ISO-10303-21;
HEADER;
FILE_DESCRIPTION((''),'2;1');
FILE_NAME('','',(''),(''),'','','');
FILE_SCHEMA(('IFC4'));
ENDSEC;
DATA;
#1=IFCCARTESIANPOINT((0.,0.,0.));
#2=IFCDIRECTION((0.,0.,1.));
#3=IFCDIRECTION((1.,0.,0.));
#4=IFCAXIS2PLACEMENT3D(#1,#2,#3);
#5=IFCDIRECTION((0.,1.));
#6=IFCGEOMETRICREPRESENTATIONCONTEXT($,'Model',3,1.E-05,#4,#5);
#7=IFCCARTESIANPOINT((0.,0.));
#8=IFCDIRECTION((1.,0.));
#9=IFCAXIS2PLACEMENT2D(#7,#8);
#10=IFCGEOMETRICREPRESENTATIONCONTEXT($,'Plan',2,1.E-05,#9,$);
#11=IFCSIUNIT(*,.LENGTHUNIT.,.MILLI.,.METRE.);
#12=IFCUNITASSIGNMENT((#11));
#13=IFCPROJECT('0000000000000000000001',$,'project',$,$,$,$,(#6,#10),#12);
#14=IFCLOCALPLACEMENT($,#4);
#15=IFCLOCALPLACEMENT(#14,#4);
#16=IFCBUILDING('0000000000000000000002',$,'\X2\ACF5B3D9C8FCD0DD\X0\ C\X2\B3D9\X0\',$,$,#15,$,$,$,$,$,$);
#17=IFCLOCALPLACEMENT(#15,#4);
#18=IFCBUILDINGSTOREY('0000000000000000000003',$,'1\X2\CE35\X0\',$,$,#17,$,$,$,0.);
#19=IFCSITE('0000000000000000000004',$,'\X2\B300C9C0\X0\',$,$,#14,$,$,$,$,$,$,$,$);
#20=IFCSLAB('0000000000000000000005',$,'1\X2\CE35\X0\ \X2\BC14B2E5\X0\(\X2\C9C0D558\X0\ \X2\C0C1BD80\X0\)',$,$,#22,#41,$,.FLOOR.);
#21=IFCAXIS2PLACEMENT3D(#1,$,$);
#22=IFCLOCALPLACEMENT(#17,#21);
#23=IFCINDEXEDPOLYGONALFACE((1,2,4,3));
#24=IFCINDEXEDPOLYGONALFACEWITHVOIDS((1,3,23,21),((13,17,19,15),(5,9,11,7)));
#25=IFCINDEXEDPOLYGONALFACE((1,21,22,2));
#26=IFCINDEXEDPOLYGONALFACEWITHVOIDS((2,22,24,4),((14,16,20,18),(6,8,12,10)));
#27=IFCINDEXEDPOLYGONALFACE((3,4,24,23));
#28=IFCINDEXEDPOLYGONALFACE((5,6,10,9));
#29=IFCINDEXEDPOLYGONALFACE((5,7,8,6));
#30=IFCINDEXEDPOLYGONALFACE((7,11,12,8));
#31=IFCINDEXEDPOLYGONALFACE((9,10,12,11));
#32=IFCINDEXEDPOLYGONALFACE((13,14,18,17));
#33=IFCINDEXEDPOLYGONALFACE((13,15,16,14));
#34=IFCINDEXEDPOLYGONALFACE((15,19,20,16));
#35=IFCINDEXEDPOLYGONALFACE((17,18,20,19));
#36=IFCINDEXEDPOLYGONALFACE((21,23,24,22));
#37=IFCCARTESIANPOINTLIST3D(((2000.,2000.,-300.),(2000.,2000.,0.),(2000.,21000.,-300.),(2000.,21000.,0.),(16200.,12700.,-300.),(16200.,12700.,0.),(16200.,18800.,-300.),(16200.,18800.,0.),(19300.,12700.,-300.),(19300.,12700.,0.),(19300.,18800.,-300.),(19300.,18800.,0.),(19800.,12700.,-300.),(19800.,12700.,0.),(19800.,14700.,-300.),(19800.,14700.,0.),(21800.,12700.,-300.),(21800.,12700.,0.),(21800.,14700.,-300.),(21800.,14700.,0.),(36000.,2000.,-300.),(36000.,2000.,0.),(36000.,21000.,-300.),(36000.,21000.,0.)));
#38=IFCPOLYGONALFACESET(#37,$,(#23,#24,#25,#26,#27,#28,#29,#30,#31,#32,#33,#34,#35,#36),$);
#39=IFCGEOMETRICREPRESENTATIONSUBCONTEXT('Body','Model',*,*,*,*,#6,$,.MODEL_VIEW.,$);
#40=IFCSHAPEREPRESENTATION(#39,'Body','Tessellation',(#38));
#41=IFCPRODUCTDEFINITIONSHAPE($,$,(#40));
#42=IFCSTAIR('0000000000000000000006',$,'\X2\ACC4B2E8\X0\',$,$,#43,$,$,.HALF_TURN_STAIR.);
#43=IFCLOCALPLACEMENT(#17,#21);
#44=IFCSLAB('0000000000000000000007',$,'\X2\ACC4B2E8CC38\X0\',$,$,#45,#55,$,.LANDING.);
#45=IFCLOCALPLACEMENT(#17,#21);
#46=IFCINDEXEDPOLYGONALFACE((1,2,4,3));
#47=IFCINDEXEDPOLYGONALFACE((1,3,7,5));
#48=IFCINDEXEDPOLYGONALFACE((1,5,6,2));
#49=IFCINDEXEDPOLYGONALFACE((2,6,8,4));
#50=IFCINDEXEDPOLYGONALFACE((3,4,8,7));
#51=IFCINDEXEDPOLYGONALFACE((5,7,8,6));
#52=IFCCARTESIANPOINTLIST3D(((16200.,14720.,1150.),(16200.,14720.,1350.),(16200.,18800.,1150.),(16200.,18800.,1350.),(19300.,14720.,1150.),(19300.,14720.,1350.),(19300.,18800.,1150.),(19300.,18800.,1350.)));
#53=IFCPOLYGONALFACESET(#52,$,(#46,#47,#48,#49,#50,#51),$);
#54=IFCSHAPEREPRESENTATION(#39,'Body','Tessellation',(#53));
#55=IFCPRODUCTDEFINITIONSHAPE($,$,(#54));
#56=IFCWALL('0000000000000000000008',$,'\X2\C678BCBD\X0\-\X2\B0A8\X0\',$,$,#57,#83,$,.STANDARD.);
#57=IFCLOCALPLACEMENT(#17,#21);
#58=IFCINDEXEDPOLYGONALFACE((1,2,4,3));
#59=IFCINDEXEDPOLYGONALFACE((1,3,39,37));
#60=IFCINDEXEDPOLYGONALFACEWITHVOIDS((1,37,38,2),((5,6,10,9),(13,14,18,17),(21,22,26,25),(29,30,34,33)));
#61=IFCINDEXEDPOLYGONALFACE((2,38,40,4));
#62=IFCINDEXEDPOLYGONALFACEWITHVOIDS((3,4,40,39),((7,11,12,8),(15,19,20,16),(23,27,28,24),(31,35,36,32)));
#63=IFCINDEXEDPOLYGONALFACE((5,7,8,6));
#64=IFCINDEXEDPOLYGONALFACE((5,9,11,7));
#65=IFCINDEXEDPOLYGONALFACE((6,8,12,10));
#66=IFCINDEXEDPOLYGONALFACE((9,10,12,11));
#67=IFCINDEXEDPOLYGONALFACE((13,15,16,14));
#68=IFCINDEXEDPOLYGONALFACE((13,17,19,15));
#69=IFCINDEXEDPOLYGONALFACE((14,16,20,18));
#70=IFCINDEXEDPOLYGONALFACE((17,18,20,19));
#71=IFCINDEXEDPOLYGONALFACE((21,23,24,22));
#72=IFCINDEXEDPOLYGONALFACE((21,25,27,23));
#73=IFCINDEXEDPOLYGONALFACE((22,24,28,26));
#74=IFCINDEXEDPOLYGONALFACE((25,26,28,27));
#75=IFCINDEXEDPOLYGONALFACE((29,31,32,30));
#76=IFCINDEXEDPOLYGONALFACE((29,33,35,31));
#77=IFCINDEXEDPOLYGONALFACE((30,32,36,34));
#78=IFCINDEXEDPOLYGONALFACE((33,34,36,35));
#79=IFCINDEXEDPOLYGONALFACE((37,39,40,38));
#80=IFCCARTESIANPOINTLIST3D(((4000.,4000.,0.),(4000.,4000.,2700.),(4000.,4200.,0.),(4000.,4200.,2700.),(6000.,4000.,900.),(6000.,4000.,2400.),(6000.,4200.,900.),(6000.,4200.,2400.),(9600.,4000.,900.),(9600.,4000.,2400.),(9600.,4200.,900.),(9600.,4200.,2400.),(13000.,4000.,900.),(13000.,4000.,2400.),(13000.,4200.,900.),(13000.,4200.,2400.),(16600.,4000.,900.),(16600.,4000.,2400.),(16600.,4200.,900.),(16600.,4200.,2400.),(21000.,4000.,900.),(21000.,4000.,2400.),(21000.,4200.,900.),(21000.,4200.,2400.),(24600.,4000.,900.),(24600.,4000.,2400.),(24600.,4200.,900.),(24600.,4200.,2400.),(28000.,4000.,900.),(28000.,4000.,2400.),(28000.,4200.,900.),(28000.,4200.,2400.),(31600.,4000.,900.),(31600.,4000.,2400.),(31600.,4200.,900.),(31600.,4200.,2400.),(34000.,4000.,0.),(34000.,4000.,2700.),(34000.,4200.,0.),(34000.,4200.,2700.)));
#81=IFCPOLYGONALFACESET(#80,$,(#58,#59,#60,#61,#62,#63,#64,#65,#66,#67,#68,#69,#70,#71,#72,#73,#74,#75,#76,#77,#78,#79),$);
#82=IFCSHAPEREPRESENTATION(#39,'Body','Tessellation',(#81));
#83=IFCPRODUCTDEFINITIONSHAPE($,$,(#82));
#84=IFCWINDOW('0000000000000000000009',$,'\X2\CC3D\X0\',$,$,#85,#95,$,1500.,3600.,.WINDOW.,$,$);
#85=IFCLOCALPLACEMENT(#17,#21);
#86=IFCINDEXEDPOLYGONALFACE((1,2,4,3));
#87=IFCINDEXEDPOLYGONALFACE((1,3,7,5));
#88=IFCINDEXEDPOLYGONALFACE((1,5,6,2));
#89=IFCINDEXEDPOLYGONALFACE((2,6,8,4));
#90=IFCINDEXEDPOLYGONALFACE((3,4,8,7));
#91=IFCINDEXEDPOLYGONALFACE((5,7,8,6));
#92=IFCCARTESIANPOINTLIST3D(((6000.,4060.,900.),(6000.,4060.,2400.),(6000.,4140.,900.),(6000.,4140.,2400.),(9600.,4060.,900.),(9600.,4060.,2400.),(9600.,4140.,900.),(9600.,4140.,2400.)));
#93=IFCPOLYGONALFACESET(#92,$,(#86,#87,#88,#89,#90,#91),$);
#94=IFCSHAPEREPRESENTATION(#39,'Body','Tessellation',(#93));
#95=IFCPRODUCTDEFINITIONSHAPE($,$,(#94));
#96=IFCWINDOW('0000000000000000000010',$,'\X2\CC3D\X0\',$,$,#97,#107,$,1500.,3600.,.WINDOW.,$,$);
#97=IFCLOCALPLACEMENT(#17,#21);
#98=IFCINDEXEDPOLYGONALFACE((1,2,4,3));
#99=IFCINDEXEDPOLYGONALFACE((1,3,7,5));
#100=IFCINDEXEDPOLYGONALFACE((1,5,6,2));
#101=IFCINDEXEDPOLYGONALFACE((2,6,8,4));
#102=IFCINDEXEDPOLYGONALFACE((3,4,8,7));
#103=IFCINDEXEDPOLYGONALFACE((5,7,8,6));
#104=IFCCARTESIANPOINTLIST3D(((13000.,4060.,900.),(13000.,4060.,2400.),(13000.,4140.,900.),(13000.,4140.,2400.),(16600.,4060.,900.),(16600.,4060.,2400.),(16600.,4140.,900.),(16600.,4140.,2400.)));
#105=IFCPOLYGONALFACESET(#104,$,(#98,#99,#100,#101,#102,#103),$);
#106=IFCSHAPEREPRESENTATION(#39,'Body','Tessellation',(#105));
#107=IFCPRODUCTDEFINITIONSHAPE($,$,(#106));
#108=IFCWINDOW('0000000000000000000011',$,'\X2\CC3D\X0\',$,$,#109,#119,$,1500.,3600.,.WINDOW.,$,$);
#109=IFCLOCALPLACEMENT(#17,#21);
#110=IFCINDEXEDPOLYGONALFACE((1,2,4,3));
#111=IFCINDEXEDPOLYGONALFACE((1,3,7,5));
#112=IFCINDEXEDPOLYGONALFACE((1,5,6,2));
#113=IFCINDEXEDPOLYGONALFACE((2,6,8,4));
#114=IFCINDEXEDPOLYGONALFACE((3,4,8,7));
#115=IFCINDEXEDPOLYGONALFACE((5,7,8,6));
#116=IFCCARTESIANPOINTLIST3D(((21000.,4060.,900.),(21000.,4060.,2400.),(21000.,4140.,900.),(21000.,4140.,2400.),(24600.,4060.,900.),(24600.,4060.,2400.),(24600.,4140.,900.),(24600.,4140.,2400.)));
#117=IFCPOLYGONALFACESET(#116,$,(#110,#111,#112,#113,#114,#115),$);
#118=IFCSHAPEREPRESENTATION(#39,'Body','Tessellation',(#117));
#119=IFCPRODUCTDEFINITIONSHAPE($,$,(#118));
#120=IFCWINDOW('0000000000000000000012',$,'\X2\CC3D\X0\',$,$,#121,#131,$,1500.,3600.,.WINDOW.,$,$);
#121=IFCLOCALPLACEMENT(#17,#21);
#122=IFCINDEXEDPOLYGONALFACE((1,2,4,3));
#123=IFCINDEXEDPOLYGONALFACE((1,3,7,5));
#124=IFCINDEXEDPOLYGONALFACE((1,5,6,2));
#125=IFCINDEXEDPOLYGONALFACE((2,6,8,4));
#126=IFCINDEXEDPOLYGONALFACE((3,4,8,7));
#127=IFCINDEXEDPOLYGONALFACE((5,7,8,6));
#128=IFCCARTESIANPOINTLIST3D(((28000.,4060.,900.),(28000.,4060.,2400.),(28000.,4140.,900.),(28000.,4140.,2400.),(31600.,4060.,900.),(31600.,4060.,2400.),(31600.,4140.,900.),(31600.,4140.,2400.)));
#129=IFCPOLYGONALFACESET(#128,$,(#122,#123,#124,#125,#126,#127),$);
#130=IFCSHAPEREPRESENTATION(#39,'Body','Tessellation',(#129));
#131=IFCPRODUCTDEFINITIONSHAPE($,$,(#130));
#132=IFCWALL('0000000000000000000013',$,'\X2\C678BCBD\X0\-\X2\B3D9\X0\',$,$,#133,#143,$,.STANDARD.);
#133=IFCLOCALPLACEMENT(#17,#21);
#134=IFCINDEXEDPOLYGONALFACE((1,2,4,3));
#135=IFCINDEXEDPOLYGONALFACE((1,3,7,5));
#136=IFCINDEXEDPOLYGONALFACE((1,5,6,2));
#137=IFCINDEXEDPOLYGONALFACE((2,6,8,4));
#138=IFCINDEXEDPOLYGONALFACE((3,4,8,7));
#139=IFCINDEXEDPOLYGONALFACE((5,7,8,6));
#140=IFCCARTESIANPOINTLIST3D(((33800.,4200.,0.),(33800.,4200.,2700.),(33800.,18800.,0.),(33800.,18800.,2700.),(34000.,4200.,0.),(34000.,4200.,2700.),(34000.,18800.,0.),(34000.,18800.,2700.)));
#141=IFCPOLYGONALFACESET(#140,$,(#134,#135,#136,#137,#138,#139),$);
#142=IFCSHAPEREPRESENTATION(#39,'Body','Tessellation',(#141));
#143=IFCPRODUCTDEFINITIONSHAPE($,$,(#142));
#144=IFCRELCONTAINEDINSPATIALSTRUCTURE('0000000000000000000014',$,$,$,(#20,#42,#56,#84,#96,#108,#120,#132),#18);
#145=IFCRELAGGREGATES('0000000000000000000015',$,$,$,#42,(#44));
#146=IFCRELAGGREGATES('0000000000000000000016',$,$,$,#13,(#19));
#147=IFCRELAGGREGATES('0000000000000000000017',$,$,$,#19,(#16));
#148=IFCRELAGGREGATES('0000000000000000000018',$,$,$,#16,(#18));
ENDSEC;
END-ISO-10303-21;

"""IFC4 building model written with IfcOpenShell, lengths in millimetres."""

from ifc_helpers import new_model, si_unit, direction, frame, origin_with_axes, origin_2d_with_axis, place, context, subcontext, project, spatial, polyline, outline, extrude, element, fill, aggregate, save


model = new_model("IFC4")

# Units and contexts
model_context = context("Model", 3, precision=1e-05, world=origin_with_axes(), true_north=direction((0.0, 1.0)))
plan_context = context("Plan", 2, precision=1e-05, world=origin_2d_with_axis())
body_context = subcontext(model_context, "Body", "Model", "MODEL_VIEW")
ifc_project = project(units=[si_unit("LENGTHUNIT", "METRE", prefix="MILLI")], contexts=[model_context, plan_context])

# Site, building, storey
site_placement = place(None, origin_with_axes())
site = spatial("IfcSite", under=ifc_project, at=site_placement, Name="대지")
building_placement = place(site_placement, origin_with_axes())
building = spatial("IfcBuilding", under=site, at=building_placement, Name="공동주택 C동")
storey_placement = place(building_placement, origin_with_axes())
storey = spatial("IfcBuildingStorey", under=building, at=storey_placement, Name="1층", Elevation=0.0)

# Slab
slab_1_placement = place(storey_placement, origin_with_axes())
element("IfcSlab", 1, at=slab_1_placement, inside=storey, Name="1층 바닥(지하 상부)", PredefinedType="FLOOR", context=body_context, shape_type="SweptSolid", body=[
    extrude(outline(polyline([(2000.0, 2000.0), (36000.0, 2000.0), (36000.0, 21000.0), (2000.0, 21000.0), (2000.0, 2000.0)]), holes=[polyline([(16200.0, 12700.0), (19300.0, 12700.0), (19300.0, 18800.0), (16200.0, 18800.0), (16200.0, 12700.0)]), polyline([(19800.0, 12700.0), (21800.0, 12700.0), (21800.0, 14700.0), (19800.0, 14700.0), (19800.0, 12700.0)])]), frame((0.0, 0.0, -300.0), z_axis=(0.0, 0.0, 1.0), x_axis=(1.0, 0.0, 0.0)), (0.0, 0.0, 1.0), 300.0),
])

# Stair, slab
stair_placement = place(storey_placement, origin_with_axes())
stair = element("IfcStair", 2, at=stair_placement, inside=storey, Name="계단", PredefinedType="HALF_TURN_STAIR")
slab_2_placement = place(stair_placement, origin_with_axes())
slab_2 = element("IfcSlab", 3, at=slab_2_placement, Name="계단참", PredefinedType="LANDING", context=body_context, shape_type="SweptSolid", body=[
    extrude(outline(polyline([(16200.0, 14720.0), (19300.0, 14720.0), (19300.0, 18800.0), (16200.0, 18800.0), (16200.0, 14720.0)])), frame((0.0, 0.0, 1150.0), z_axis=(0.0, 0.0, 1.0), x_axis=(1.0, 0.0, 0.0)), (0.0, 0.0, 1.0), 200.0),
])

# Wall, openings, windows
wall_1_placement = place(storey_placement, origin_with_axes())
wall_1 = element("IfcWall", 4, at=wall_1_placement, inside=storey, Name="외벽-남", PredefinedType="STANDARD", context=body_context, shape_type="SweptSolid", body=[
    extrude(outline(polyline([(4000.0, 4200.0), (34000.0, 4200.0), (34000.0, 4000.0), (4000.0, 4000.0), (4000.0, 4200.0)])), origin_with_axes(), (0.0, 0.0, 1.0), 2700.0),
])
opening_1_placement = place(storey_placement, origin_with_axes())
opening_1 = element("IfcOpeningElement", 5, at=opening_1_placement, cuts=wall_1, PredefinedType="OPENING", context=body_context, shape_type="SweptSolid", body=[
    extrude(outline(polyline([(6000.0, 3950.0), (9600.0, 3950.0), (9600.0, 4250.0), (6000.0, 4250.0), (6000.0, 3950.0)])), frame((0.0, 0.0, 900.0), z_axis=(0.0, 0.0, 1.0), x_axis=(1.0, 0.0, 0.0)), (0.0, 0.0, 1.0), 1500.0),
])
opening_2_placement = place(storey_placement, origin_with_axes())
opening_2 = element("IfcOpeningElement", 6, at=opening_2_placement, cuts=wall_1, PredefinedType="OPENING", context=body_context, shape_type="SweptSolid", body=[
    extrude(outline(polyline([(13000.0, 3950.0), (16600.0, 3950.0), (16600.0, 4250.0), (13000.0, 4250.0), (13000.0, 3950.0)])), frame((0.0, 0.0, 900.0), z_axis=(0.0, 0.0, 1.0), x_axis=(1.0, 0.0, 0.0)), (0.0, 0.0, 1.0), 1500.0),
])
opening_3_placement = place(storey_placement, origin_with_axes())
opening_3 = element("IfcOpeningElement", 7, at=opening_3_placement, cuts=wall_1, PredefinedType="OPENING", context=body_context, shape_type="SweptSolid", body=[
    extrude(outline(polyline([(21000.0, 3950.0), (24600.0, 3950.0), (24600.0, 4250.0), (21000.0, 4250.0), (21000.0, 3950.0)])), frame((0.0, 0.0, 900.0), z_axis=(0.0, 0.0, 1.0), x_axis=(1.0, 0.0, 0.0)), (0.0, 0.0, 1.0), 1500.0),
])
opening_4_placement = place(storey_placement, origin_with_axes())
opening_4 = element("IfcOpeningElement", 8, at=opening_4_placement, cuts=wall_1, PredefinedType="OPENING", context=body_context, shape_type="SweptSolid", body=[
    extrude(outline(polyline([(28000.0, 3950.0), (31600.0, 3950.0), (31600.0, 4250.0), (28000.0, 4250.0), (28000.0, 3950.0)])), frame((0.0, 0.0, 900.0), z_axis=(0.0, 0.0, 1.0), x_axis=(1.0, 0.0, 0.0)), (0.0, 0.0, 1.0), 1500.0),
])
window_1_placement = place(storey_placement, origin_with_axes())
window_1 = element("IfcWindow", 9, at=window_1_placement, inside=storey, Name="창", OverallHeight=1500.0, OverallWidth=3600.0, PredefinedType="WINDOW", context=body_context, shape_type="SweptSolid", body=[
    extrude(outline(polyline([(6000.0, 4060.0), (9600.0, 4060.0), (9600.0, 4140.0), (6000.0, 4140.0), (6000.0, 4060.0)])), frame((0.0, 0.0, 900.0), z_axis=(0.0, 0.0, 1.0), x_axis=(1.0, 0.0, 0.0)), (0.0, 0.0, 1.0), 1500.0),
])
fill(opening_1, window_1)
window_2_placement = place(storey_placement, origin_with_axes())
window_2 = element("IfcWindow", 10, at=window_2_placement, inside=storey, Name="창", OverallHeight=1500.0, OverallWidth=3600.0, PredefinedType="WINDOW", context=body_context, shape_type="SweptSolid", body=[
    extrude(outline(polyline([(13000.0, 4060.0), (16600.0, 4060.0), (16600.0, 4140.0), (13000.0, 4140.0), (13000.0, 4060.0)])), frame((0.0, 0.0, 900.0), z_axis=(0.0, 0.0, 1.0), x_axis=(1.0, 0.0, 0.0)), (0.0, 0.0, 1.0), 1500.0),
])
fill(opening_2, window_2)
window_3_placement = place(storey_placement, origin_with_axes())
window_3 = element("IfcWindow", 11, at=window_3_placement, inside=storey, Name="창", OverallHeight=1500.0, OverallWidth=3600.0, PredefinedType="WINDOW", context=body_context, shape_type="SweptSolid", body=[
    extrude(outline(polyline([(21000.0, 4060.0), (24600.0, 4060.0), (24600.0, 4140.0), (21000.0, 4140.0), (21000.0, 4060.0)])), frame((0.0, 0.0, 900.0), z_axis=(0.0, 0.0, 1.0), x_axis=(1.0, 0.0, 0.0)), (0.0, 0.0, 1.0), 1500.0),
])
fill(opening_3, window_3)
window_4_placement = place(storey_placement, origin_with_axes())
window_4 = element("IfcWindow", 12, at=window_4_placement, inside=storey, Name="창", OverallHeight=1500.0, OverallWidth=3600.0, PredefinedType="WINDOW", context=body_context, shape_type="SweptSolid", body=[
    extrude(outline(polyline([(28000.0, 4060.0), (31600.0, 4060.0), (31600.0, 4140.0), (28000.0, 4140.0), (28000.0, 4060.0)])), frame((0.0, 0.0, 900.0), z_axis=(0.0, 0.0, 1.0), x_axis=(1.0, 0.0, 0.0)), (0.0, 0.0, 1.0), 1500.0),
])
fill(opening_4, window_4)

# Wall
wall_2_placement = place(storey_placement, origin_with_axes())
element("IfcWall", 13, at=wall_2_placement, inside=storey, Name="외벽-동", PredefinedType="STANDARD", context=body_context, shape_type="SweptSolid", body=[
    extrude(outline(polyline([(33800.0, 4200.0), (33800.0, 18800.0), (34000.0, 18800.0), (34000.0, 4200.0), (33800.0, 4200.0)])), origin_with_axes(), (0.0, 0.0, 1.0), 2700.0),
])

aggregate(stair, [slab_2])

save(model, "model.ifc")
